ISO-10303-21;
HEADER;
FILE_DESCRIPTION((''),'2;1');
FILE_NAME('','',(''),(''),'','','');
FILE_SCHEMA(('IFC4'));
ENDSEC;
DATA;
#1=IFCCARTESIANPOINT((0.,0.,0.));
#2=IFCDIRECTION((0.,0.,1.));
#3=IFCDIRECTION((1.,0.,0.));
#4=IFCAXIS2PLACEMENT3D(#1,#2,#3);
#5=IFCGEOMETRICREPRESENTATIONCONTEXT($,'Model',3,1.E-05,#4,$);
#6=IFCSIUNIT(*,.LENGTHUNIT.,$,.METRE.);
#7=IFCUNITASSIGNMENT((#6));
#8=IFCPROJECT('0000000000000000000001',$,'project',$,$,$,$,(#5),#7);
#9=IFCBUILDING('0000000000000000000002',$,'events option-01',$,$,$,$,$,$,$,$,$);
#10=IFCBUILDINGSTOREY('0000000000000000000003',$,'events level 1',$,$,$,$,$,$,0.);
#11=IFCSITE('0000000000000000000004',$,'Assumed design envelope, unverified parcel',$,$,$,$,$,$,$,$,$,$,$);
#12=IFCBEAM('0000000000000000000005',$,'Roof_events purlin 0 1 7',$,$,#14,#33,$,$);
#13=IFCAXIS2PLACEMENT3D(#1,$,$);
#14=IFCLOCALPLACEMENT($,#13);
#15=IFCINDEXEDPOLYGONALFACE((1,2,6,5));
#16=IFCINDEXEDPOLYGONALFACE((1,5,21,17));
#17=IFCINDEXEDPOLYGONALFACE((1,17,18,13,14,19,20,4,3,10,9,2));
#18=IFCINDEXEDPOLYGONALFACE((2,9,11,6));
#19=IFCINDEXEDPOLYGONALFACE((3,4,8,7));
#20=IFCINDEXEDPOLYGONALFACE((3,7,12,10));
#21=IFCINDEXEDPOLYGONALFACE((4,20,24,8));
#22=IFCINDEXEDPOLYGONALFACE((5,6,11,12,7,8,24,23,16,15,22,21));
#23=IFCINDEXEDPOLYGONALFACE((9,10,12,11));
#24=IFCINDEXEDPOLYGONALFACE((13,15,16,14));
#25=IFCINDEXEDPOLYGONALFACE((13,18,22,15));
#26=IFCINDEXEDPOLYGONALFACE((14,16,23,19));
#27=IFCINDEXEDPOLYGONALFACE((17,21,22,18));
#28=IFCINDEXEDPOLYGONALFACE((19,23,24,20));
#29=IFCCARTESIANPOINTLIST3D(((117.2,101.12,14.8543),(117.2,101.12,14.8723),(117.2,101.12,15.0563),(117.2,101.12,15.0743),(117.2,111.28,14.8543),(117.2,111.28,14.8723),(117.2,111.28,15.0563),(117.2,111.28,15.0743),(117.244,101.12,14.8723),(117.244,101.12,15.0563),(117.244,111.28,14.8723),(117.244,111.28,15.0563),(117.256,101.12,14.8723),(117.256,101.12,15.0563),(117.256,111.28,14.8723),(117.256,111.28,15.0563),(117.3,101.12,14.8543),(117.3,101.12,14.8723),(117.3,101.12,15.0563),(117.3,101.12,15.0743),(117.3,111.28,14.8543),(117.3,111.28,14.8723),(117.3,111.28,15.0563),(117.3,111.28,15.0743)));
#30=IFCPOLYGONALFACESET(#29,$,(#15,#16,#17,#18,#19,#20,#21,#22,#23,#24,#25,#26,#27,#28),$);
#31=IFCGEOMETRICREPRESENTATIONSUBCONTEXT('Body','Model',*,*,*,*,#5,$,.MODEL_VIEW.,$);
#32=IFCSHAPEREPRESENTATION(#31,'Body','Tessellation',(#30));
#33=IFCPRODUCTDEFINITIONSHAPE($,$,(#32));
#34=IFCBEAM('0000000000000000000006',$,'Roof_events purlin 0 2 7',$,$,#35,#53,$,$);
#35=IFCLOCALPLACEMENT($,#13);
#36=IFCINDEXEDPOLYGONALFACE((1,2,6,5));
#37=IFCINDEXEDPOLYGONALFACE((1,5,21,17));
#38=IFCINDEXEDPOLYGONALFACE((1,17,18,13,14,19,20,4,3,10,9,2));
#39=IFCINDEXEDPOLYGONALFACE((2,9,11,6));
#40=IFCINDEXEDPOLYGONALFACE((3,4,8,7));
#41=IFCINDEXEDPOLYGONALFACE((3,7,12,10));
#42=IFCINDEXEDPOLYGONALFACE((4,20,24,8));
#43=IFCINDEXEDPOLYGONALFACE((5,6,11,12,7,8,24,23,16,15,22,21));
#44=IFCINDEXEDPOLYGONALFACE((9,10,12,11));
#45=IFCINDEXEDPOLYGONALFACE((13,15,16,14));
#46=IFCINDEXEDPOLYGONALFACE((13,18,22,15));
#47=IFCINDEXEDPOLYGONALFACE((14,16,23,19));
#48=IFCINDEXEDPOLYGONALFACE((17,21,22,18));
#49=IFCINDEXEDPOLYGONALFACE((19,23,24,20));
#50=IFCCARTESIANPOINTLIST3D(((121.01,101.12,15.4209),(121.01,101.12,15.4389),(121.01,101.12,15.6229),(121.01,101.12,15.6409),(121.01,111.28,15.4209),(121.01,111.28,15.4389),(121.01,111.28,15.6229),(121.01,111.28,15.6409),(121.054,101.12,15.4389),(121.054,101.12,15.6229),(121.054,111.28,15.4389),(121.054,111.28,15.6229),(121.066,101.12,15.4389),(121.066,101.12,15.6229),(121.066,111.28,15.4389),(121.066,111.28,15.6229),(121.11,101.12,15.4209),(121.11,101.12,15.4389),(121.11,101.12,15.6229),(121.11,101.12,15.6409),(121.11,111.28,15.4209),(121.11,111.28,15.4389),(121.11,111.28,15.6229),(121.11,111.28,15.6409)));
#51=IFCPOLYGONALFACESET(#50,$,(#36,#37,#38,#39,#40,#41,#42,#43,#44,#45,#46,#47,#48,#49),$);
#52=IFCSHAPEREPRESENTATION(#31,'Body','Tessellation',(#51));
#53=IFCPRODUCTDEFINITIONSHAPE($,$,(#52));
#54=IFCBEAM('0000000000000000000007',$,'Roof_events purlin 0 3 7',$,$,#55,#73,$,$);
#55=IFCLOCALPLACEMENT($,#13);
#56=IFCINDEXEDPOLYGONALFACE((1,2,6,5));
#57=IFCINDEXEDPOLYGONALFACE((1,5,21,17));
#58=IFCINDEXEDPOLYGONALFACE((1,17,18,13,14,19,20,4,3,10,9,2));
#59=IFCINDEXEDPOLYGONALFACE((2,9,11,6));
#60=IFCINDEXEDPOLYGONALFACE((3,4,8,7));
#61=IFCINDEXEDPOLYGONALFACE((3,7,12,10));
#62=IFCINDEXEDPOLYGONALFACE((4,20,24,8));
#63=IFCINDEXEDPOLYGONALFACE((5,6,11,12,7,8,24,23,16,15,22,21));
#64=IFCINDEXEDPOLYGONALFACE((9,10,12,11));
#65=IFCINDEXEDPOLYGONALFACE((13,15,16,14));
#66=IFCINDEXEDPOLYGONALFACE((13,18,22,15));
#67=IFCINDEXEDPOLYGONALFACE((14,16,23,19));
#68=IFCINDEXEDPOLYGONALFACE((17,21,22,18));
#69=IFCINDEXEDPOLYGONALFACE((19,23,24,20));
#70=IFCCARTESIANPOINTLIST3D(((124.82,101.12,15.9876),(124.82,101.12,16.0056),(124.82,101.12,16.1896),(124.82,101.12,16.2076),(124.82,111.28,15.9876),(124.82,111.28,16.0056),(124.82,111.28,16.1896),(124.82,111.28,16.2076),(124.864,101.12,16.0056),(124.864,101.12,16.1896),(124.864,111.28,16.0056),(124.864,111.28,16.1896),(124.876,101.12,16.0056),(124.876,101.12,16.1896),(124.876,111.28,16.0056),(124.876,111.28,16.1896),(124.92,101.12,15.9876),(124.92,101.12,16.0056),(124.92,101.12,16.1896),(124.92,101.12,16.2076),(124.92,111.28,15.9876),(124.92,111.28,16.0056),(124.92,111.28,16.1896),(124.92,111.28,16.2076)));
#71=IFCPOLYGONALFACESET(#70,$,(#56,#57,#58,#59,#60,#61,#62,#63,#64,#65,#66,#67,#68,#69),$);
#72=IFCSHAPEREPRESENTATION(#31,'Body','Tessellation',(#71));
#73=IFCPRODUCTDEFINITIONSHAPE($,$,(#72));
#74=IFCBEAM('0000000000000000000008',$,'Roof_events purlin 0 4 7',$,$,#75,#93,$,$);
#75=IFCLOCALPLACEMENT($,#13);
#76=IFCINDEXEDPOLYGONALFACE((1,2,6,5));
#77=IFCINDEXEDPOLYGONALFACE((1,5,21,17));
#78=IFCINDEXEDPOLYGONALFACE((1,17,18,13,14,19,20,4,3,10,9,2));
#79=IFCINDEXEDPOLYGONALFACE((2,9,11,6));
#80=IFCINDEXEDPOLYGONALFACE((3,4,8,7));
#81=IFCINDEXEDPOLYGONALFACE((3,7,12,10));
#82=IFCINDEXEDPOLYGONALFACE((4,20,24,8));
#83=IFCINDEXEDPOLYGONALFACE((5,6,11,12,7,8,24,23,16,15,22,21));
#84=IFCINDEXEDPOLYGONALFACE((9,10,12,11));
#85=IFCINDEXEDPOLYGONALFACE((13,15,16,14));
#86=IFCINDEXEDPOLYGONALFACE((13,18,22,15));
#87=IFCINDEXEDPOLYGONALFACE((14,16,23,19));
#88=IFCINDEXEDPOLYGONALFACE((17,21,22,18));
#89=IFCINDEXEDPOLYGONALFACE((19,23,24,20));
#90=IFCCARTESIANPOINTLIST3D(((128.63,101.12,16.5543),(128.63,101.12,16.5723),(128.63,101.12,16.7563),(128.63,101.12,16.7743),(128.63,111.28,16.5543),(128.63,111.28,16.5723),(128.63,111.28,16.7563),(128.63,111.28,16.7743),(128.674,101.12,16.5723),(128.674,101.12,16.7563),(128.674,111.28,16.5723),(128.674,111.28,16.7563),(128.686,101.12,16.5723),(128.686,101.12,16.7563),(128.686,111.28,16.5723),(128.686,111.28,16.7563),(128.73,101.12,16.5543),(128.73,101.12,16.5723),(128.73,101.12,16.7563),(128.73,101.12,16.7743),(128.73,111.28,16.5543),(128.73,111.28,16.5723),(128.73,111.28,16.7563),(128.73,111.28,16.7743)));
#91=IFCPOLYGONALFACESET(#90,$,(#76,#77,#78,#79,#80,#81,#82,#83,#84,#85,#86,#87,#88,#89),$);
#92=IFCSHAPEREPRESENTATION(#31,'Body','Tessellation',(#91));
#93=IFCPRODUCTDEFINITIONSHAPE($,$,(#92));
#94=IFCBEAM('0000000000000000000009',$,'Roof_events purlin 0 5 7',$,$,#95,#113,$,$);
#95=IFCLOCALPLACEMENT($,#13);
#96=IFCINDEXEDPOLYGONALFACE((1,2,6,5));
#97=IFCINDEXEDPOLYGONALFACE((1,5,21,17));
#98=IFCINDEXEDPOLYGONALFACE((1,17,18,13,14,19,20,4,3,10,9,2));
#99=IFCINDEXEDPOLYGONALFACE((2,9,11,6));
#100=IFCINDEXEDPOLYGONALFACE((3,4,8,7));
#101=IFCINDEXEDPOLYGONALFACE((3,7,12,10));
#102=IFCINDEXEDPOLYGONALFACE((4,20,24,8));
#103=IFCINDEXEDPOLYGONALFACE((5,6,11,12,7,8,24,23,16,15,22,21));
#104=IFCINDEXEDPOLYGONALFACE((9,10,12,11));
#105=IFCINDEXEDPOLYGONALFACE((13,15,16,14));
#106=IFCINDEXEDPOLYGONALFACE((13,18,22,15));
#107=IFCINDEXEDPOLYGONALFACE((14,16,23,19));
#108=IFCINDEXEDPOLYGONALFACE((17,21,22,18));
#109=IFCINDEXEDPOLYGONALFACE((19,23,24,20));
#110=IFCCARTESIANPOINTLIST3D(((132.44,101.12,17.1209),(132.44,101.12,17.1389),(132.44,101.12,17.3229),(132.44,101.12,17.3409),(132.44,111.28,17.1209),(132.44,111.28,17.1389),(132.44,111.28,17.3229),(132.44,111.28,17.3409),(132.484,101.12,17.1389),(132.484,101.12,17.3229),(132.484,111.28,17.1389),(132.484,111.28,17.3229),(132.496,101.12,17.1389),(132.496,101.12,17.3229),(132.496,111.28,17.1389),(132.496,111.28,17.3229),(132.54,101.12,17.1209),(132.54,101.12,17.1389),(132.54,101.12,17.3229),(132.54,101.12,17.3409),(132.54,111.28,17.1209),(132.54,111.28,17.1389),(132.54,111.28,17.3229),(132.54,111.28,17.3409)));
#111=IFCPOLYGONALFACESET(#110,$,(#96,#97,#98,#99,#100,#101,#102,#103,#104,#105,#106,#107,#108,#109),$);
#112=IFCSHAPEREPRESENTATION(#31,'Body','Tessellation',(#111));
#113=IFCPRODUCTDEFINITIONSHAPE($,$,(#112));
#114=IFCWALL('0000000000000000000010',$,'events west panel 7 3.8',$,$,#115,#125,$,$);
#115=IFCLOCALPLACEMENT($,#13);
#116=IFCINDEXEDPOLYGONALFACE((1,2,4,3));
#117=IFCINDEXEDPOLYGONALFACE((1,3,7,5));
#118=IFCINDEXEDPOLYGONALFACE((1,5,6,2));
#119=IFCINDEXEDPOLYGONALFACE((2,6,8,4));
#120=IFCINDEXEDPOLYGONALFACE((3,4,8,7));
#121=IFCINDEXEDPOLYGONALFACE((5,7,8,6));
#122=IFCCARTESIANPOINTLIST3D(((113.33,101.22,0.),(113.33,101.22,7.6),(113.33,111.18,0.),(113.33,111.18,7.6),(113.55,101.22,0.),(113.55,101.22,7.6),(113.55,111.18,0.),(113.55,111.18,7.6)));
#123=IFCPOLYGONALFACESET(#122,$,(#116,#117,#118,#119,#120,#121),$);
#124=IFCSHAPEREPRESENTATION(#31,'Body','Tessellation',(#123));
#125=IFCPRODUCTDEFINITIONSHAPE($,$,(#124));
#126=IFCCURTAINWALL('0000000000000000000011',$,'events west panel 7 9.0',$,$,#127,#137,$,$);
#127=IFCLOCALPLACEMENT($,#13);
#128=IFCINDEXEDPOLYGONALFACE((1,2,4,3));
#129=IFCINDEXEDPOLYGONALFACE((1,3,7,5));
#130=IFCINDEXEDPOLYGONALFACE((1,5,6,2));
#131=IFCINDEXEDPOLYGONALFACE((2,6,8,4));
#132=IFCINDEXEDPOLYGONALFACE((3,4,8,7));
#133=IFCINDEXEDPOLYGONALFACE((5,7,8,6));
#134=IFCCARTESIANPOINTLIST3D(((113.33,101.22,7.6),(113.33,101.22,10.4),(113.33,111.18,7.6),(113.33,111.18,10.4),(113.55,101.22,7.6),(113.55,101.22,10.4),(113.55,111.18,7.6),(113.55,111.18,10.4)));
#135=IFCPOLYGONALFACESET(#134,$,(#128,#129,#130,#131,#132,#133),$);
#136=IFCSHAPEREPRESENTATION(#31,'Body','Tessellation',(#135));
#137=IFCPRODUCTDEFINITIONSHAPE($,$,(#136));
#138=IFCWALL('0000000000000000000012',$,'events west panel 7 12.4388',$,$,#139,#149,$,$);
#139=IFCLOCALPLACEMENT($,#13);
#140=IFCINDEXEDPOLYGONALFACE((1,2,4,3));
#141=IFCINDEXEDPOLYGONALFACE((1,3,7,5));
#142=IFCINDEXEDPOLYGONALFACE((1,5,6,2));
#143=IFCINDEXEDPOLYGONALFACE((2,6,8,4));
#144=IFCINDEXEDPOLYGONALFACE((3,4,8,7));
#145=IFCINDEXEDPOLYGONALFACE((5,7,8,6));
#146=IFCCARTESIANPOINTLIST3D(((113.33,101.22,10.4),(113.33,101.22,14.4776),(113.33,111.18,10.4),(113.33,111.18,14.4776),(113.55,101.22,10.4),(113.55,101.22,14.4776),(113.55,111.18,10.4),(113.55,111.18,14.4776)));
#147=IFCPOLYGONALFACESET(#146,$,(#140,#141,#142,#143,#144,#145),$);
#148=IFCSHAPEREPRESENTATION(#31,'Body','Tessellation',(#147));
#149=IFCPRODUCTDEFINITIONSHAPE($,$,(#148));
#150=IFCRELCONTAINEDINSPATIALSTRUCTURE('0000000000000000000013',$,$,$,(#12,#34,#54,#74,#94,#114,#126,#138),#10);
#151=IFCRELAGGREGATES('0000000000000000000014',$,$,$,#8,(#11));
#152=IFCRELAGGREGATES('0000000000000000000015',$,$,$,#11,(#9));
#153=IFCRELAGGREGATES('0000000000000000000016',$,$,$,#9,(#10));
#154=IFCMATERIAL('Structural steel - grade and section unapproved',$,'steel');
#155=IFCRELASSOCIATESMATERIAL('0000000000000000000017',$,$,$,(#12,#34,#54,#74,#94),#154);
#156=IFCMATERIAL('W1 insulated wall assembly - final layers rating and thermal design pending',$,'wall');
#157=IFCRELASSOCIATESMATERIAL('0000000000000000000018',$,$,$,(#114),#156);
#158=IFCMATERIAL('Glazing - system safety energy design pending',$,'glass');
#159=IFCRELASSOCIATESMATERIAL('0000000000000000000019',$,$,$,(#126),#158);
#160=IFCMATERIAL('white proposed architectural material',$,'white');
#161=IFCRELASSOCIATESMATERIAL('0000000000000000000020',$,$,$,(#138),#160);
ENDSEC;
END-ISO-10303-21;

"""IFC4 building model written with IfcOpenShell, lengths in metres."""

from ifc_helpers import new_model, si_unit, frame, origin_with_axes, place, context, subcontext, project, spatial, rectangle, i_section, extrude, material, element, save


model = new_model("IFC4")

# Units and contexts
model_context = context("Model", 3, precision=1e-05, world=origin_with_axes())
body_context = subcontext(model_context, "Body", "Model", "MODEL_VIEW")
ifc_project = project(units=[si_unit("LENGTHUNIT", "METRE")], contexts=[model_context])

# Site, building, storey
site = spatial("IfcSite", under=ifc_project, Name="Assumed design envelope, unverified parcel")
building = spatial("IfcBuilding", under=site, Name="events option-01")
storey = spatial("IfcBuildingStorey", under=building, Name="events level 1", Elevation=0.0)

# Shared definitions
ifc_material_1 = material(Name="Structural steel - grade and section unapproved", Category="steel")

# Beams
for number, where, z_axis, x_axis, name in (
    (1, (117.25, 101.12, 14.9643), (0.0, 1.0, 0.0), (-1.0, 0.0, 0.0), "Roof_events purlin 0 1 7"),
    (2, (121.06, 101.12, 15.5309), (0.0, 1.0, 0.0), (-1.0, 0.0, 0.0), "Roof_events purlin 0 2 7"),
    (3, (124.87, 101.12, 16.0976), (0.0, 1.0, 0.0), (-1.0, 0.0, 0.0), "Roof_events purlin 0 3 7"),
    (4, (128.68, 101.12, 16.6643), (0.0, 1.0, 0.0), (-1.0, 0.0, 0.0), "Roof_events purlin 0 4 7"),
    (5, (132.49, 101.12, 17.2309), (0.0, 1.0, 0.0), (-1.0, 0.0, 0.0), "Roof_events purlin 0 5 7"),
):
    element("IfcBeam", number, at=place(None, frame(where, z_axis=z_axis, x_axis=x_axis)), inside=storey, material=ifc_material_1, Name=name, context=body_context, shape_type="SweptSolid", body=[
        extrude(i_section(OverallWidth=0.1, OverallDepth=0.22, WebThickness=0.012, FlangeThickness=0.018, FilletRadius=0.0), origin_with_axes(), (0.0, 0.0, 1.0), 10.16),
    ])

# Wall
ifc_material_2 = material(Name="W1 insulated wall assembly - final layers rating and thermal design pending", Category="wall")
wall_1_placement = place(None, frame((113.44, 106.2, 0.0), z_axis=(0.0, 0.0, 1.0), x_axis=(1.0, 0.0, 0.0)))
element("IfcWall", 6, at=wall_1_placement, inside=storey, material=ifc_material_2, Name="events west panel 7 3.8", context=body_context, shape_type="SweptSolid", body=[
    extrude(rectangle(XDim=0.22, YDim=9.96), origin_with_axes(), (0.0, 0.0, 1.0), 7.6),
])

# Curtain wall
ifc_material_3 = material(Name="Glazing - system safety energy design pending", Category="glass")
curtain_wall_placement = place(None, frame((113.44, 106.2, 7.6), z_axis=(0.0, 0.0, 1.0), x_axis=(1.0, 0.0, 0.0)))
element("IfcCurtainWall", 7, at=curtain_wall_placement, inside=storey, material=ifc_material_3, Name="events west panel 7 9.0", context=body_context, shape_type="SweptSolid", body=[
    extrude(rectangle(XDim=0.22, YDim=9.96), origin_with_axes(), (0.0, 0.0, 1.0), 2.8),
])

# Wall
ifc_material_4 = material(Name="white proposed architectural material", Category="white")
wall_2_placement = place(None, frame((113.44, 106.2, 10.4), z_axis=(0.0, 0.0, 1.0), x_axis=(1.0, 0.0, 0.0)))
element("IfcWall", 8, at=wall_2_placement, inside=storey, material=ifc_material_4, Name="events west panel 7 12.4388", context=body_context, shape_type="SweptSolid", body=[
    extrude(rectangle(XDim=0.22, YDim=9.96), origin_with_axes(), (0.0, 0.0, 1.0), 4.0776),
])

save(model, "model.ifc")
